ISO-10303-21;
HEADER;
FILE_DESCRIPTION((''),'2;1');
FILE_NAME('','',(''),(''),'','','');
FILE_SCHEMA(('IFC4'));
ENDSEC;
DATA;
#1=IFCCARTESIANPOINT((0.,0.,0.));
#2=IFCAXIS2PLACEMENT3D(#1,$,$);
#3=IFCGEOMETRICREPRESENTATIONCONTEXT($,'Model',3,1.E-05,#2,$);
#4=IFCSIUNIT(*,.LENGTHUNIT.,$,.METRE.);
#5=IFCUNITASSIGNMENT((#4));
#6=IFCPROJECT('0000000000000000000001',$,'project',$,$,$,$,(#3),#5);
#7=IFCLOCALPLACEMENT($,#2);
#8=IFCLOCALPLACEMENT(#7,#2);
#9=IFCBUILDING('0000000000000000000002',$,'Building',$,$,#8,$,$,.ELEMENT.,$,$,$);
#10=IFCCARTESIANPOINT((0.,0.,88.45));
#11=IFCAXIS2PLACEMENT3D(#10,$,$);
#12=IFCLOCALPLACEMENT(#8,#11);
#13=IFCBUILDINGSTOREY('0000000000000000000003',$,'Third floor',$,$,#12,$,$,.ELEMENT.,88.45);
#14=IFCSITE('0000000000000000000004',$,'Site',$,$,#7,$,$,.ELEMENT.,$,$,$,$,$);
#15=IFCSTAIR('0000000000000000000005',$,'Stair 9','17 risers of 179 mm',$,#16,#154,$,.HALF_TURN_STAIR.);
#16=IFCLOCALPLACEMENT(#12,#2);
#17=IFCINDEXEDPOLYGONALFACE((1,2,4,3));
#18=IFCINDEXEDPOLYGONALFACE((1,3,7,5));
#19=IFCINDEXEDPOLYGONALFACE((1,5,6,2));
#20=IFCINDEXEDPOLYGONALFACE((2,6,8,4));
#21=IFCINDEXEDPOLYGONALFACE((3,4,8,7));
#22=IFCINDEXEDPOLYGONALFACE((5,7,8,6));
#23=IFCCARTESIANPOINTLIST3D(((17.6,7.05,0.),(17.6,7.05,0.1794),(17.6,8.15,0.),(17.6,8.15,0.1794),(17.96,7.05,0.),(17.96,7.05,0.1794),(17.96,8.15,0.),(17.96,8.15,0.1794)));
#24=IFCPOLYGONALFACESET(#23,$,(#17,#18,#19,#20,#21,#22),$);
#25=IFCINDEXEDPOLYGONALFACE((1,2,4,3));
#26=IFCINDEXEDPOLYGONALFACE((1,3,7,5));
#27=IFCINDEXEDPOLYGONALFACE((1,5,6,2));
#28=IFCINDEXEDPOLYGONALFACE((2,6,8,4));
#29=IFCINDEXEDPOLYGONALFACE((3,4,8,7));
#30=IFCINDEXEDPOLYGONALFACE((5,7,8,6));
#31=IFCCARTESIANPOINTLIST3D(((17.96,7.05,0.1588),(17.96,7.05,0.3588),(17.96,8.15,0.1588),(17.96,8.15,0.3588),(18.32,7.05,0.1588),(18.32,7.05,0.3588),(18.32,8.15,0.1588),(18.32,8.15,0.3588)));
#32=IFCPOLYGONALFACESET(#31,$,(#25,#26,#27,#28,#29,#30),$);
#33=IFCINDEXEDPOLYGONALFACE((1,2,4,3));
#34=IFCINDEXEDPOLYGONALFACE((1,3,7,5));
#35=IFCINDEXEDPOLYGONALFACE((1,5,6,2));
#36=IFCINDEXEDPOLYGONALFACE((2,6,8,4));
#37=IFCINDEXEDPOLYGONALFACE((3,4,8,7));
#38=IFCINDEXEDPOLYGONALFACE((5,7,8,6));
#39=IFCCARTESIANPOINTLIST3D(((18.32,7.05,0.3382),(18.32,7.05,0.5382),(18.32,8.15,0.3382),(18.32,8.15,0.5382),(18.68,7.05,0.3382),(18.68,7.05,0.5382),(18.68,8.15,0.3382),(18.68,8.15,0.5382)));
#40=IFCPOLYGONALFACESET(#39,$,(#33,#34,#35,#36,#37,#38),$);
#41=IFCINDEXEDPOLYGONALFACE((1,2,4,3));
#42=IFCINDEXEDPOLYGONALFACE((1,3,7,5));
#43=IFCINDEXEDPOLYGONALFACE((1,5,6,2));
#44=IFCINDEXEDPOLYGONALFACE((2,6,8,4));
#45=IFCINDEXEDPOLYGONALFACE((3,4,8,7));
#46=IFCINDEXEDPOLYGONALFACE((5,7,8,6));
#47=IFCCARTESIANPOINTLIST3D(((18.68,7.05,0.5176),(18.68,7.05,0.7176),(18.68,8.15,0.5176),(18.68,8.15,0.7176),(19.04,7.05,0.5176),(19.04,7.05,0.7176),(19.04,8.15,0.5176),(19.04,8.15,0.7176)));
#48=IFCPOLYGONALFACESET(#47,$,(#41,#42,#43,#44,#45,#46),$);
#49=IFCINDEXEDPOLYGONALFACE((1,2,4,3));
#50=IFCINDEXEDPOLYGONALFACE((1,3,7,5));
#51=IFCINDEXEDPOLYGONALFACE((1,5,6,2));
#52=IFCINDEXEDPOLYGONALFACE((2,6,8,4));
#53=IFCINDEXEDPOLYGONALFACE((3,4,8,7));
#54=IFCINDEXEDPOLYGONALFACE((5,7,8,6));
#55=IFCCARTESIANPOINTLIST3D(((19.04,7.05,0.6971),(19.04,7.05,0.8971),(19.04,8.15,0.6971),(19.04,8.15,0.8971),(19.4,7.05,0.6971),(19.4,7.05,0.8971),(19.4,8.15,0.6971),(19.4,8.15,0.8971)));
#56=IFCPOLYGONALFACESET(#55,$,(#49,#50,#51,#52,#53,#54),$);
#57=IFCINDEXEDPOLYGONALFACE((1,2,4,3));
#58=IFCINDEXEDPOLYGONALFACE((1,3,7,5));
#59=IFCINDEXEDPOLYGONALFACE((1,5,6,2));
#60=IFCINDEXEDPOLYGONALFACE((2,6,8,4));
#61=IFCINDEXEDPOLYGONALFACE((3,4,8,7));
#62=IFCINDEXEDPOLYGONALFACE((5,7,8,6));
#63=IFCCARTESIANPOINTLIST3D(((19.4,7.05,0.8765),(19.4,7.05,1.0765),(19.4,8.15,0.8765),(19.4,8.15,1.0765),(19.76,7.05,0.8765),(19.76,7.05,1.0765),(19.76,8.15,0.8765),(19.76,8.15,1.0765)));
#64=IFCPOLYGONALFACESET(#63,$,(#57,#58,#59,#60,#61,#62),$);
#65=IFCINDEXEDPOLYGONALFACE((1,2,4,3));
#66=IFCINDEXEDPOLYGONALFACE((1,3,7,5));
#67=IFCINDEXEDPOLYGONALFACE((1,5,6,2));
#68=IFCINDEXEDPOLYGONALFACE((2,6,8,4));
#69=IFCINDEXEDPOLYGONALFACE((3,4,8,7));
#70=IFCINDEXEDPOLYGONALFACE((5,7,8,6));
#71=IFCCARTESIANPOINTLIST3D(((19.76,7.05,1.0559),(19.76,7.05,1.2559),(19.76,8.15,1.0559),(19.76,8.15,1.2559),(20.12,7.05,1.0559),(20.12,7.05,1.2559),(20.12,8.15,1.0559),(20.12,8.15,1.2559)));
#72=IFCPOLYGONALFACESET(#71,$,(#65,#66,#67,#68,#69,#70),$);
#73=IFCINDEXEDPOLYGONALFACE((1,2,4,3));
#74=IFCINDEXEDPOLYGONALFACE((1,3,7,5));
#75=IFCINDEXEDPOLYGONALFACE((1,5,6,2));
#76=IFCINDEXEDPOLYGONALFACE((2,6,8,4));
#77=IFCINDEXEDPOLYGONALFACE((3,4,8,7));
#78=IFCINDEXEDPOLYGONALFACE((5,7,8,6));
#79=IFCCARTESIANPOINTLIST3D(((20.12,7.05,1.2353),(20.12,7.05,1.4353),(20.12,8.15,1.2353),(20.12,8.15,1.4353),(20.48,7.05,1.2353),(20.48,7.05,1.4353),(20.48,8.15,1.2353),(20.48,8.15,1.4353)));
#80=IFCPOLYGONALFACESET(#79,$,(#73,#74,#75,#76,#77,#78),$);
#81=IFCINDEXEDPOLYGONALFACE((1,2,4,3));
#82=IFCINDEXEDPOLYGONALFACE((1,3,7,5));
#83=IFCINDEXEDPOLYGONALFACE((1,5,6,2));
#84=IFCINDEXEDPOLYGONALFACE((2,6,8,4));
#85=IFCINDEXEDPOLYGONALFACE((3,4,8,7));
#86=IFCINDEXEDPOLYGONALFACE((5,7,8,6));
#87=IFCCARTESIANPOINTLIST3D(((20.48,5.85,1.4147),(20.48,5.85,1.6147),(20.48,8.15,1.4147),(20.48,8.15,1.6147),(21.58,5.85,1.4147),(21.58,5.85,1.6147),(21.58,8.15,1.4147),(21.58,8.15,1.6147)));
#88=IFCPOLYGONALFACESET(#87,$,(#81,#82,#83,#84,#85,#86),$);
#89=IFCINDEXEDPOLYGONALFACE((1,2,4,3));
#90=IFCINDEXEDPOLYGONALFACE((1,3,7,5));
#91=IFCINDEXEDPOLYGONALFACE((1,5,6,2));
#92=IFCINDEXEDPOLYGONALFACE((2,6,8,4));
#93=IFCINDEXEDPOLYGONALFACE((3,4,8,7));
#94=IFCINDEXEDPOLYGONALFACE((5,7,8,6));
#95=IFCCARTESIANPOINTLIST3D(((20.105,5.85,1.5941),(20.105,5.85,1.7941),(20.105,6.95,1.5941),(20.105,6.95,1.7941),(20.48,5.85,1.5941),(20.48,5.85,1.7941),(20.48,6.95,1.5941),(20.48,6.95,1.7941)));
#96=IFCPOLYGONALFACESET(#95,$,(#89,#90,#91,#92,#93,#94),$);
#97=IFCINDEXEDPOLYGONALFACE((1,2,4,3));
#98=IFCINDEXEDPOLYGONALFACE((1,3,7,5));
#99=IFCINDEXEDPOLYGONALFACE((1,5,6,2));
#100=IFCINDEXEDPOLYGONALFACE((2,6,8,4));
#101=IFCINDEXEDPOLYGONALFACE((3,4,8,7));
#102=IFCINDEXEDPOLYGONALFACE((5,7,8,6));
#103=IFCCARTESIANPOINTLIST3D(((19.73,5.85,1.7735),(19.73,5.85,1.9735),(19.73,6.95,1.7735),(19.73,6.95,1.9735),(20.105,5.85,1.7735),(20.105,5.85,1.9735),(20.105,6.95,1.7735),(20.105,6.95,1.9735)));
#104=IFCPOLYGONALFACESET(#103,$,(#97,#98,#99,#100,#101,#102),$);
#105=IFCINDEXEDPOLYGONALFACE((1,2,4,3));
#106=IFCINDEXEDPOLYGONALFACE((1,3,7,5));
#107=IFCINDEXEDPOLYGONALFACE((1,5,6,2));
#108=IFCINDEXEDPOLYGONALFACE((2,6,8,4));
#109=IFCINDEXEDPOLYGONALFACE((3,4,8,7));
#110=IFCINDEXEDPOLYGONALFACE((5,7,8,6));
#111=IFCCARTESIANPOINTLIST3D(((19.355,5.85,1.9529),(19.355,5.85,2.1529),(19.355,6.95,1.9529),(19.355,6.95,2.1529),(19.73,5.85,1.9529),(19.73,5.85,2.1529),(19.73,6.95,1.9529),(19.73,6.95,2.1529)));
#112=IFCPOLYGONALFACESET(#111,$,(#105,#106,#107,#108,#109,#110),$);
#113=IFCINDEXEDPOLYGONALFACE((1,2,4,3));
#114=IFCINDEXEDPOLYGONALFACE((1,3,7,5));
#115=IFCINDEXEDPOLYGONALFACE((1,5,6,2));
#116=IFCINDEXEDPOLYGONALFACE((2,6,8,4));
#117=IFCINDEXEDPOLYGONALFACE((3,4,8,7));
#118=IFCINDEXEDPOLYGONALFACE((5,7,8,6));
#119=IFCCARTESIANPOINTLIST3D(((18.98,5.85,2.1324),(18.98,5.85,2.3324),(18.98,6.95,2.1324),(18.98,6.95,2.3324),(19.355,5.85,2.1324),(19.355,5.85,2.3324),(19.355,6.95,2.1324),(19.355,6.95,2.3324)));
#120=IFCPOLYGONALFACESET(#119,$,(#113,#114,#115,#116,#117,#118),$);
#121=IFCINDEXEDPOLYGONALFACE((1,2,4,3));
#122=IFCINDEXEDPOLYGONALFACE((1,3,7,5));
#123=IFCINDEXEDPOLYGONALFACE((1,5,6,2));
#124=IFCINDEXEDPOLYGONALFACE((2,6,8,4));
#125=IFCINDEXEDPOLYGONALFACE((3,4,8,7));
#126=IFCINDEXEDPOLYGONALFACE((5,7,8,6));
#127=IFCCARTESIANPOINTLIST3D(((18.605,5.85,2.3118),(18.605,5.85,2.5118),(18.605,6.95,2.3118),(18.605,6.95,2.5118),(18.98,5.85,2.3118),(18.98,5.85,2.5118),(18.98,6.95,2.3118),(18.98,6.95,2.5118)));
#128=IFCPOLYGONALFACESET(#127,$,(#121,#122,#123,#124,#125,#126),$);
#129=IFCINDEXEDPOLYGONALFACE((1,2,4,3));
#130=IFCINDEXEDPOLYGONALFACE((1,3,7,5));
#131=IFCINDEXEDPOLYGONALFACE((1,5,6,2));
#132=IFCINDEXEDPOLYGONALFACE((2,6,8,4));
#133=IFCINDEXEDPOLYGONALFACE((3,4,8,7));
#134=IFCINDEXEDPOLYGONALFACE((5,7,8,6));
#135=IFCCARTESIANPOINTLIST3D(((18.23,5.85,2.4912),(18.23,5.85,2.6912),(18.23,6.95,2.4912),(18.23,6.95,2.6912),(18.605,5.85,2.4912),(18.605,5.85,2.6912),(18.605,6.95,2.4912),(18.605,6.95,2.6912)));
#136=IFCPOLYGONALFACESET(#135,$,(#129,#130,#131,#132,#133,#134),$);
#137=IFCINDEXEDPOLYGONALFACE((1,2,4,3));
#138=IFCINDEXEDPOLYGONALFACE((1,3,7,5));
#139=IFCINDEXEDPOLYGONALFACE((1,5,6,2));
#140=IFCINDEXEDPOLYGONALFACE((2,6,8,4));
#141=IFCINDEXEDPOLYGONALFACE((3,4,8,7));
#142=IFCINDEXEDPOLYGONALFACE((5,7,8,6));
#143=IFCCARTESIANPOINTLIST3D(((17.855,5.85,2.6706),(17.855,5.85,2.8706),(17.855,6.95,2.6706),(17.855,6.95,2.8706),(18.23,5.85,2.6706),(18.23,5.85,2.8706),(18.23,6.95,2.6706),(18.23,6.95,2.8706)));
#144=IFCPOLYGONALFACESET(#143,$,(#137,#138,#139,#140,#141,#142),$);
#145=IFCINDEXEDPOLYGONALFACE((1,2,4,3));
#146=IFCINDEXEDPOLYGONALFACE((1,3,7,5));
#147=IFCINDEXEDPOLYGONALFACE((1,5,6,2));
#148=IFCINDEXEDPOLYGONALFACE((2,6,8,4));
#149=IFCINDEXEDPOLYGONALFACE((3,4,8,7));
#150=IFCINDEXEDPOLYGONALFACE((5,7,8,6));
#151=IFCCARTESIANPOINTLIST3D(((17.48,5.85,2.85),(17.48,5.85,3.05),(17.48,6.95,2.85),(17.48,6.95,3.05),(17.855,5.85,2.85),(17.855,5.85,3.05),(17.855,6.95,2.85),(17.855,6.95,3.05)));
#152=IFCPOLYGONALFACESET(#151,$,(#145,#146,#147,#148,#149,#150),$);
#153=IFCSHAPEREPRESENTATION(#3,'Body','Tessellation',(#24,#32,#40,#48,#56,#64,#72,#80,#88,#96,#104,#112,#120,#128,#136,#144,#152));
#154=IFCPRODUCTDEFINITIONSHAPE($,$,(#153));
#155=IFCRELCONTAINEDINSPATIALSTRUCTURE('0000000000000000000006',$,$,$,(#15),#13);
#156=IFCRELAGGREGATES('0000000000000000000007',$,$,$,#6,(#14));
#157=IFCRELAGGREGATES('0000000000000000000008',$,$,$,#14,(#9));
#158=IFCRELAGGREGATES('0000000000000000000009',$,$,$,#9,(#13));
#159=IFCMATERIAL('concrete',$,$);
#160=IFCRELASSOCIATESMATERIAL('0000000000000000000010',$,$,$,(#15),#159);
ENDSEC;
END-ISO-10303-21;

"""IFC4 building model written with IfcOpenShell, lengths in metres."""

from ifc_helpers import new_model, si_unit, frame, origin, place, context, project, spatial, polyline, outline, extrude, material, element, save


model = new_model("IFC4")

# Units and contexts
model_context = context("Model", 3, precision=1e-05, world=origin())
ifc_project = project(units=[si_unit("LENGTHUNIT", "METRE")], contexts=[model_context])

# Site, building, storey
site_placement = place(None, origin())
site = spatial("IfcSite", under=ifc_project, at=site_placement, Name="Site", CompositionType="ELEMENT")
building_placement = place(site_placement, origin())
building = spatial("IfcBuilding", under=site, at=building_placement, Name="Building", CompositionType="ELEMENT")
storey_placement = place(building_placement, frame((0.0, 0.0, 88.45)))
storey = spatial("IfcBuildingStorey", under=building, at=storey_placement, Name="Third floor", CompositionType="ELEMENT", Elevation=88.45)

# Shared definitions
ifc_material = material(Name="concrete")

# Stair
stair_1_placement = place(storey_placement, frame((17.6, 7.6, 0.0), z_axis=(0.0, 0.0, 1.0), x_axis=(1.0, 0.0, 0.0)))
element("IfcStair", 1, at=stair_1_placement, inside=storey, material=ifc_material, Name="Stair 9", Description="17 risers of 179 mm", PredefinedType="HALF_TURN_STAIR", context=model_context, shape_type="SweptSolid", body=[
    extrude(outline(polyline([(0.0, -0.55), (0.36, -0.55), (0.36, 0.55), (0.0, 0.55), (0.0, -0.55)])), origin(), (0.0, 0.0, 1.0), 0.1794),
    extrude(outline(polyline([(0.36, -0.55), (0.72, -0.55), (0.72, 0.55), (0.36, 0.55), (0.36, -0.55)])), frame((0.0, 0.0, 0.1588)), (0.0, 0.0, 1.0), 0.2),
    extrude(outline(polyline([(0.72, -0.55), (1.08, -0.55), (1.08, 0.55), (0.72, 0.55), (0.72, -0.55)])), frame((0.0, 0.0, 0.3382)), (0.0, 0.0, 1.0), 0.2),
    extrude(outline(polyline([(1.08, -0.55), (1.44, -0.55), (1.44, 0.55), (1.08, 0.55), (1.08, -0.55)])), frame((0.0, 0.0, 0.5176)), (0.0, 0.0, 1.0), 0.2),
    extrude(outline(polyline([(1.44, -0.55), (1.8, -0.55), (1.8, 0.55), (1.44, 0.55), (1.44, -0.55)])), frame((0.0, 0.0, 0.6971)), (0.0, 0.0, 1.0), 0.2),
    extrude(outline(polyline([(1.8, -0.55), (2.16, -0.55), (2.16, 0.55), (1.8, 0.55), (1.8, -0.55)])), frame((0.0, 0.0, 0.8765)), (0.0, 0.0, 1.0), 0.2),
    extrude(outline(polyline([(2.16, -0.55), (2.52, -0.55), (2.52, 0.55), (2.16, 0.55), (2.16, -0.55)])), frame((0.0, 0.0, 1.0559)), (0.0, 0.0, 1.0), 0.2),
    extrude(outline(polyline([(2.52, -0.55), (2.88, -0.55), (2.88, 0.55), (2.52, 0.55), (2.52, -0.55)])), frame((0.0, 0.0, 1.2353)), (0.0, 0.0, 1.0), 0.2),
    extrude(outline(polyline([(2.88, -1.75), (3.98, -1.75), (3.98, 0.55), (2.88, 0.55), (2.88, -1.75)])), frame((0.0, 0.0, 1.4147)), (0.0, 0.0, 1.0), 0.2),
    extrude(outline(polyline([(2.505, -1.75), (2.88, -1.75), (2.88, -0.65), (2.505, -0.65), (2.505, -1.75)])), frame((0.0, 0.0, 1.5941)), (0.0, 0.0, 1.0), 0.2),
    extrude(outline(polyline([(2.13, -1.75), (2.505, -1.75), (2.505, -0.65), (2.13, -0.65), (2.13, -1.75)])), frame((0.0, 0.0, 1.7735)), (0.0, 0.0, 1.0), 0.2),
    extrude(outline(polyline([(1.755, -1.75), (2.13, -1.75), (2.13, -0.65), (1.755, -0.65), (1.755, -1.75)])), frame((0.0, 0.0, 1.9529)), (0.0, 0.0, 1.0), 0.2),
    extrude(outline(polyline([(1.38, -1.75), (1.755, -1.75), (1.755, -0.65), (1.38, -0.65), (1.38, -1.75)])), frame((0.0, 0.0, 2.1324)), (0.0, 0.0, 1.0), 0.2),
    extrude(outline(polyline([(1.005, -1.75), (1.38, -1.75), (1.38, -0.65), (1.005, -0.65), (1.005, -1.75)])), frame((0.0, 0.0, 2.3118)), (0.0, 0.0, 1.0), 0.2),
    extrude(outline(polyline([(0.63, -1.75), (1.005, -1.75), (1.005, -0.65), (0.63, -0.65), (0.63, -1.75)])), frame((0.0, 0.0, 2.4912)), (0.0, 0.0, 1.0), 0.2),
    extrude(outline(polyline([(0.255, -1.75), (0.63, -1.75), (0.63, -0.65), (0.255, -0.65), (0.255, -1.75)])), frame((0.0, 0.0, 2.6706)), (0.0, 0.0, 1.0), 0.2),
    extrude(outline(polyline([(-0.12, -1.75), (0.255, -1.75), (0.255, -0.65), (-0.12, -0.65), (-0.12, -1.75)])), frame((0.0, 0.0, 2.85)), (0.0, 0.0, 1.0), 0.2),
])

save(model, "model.ifc")
